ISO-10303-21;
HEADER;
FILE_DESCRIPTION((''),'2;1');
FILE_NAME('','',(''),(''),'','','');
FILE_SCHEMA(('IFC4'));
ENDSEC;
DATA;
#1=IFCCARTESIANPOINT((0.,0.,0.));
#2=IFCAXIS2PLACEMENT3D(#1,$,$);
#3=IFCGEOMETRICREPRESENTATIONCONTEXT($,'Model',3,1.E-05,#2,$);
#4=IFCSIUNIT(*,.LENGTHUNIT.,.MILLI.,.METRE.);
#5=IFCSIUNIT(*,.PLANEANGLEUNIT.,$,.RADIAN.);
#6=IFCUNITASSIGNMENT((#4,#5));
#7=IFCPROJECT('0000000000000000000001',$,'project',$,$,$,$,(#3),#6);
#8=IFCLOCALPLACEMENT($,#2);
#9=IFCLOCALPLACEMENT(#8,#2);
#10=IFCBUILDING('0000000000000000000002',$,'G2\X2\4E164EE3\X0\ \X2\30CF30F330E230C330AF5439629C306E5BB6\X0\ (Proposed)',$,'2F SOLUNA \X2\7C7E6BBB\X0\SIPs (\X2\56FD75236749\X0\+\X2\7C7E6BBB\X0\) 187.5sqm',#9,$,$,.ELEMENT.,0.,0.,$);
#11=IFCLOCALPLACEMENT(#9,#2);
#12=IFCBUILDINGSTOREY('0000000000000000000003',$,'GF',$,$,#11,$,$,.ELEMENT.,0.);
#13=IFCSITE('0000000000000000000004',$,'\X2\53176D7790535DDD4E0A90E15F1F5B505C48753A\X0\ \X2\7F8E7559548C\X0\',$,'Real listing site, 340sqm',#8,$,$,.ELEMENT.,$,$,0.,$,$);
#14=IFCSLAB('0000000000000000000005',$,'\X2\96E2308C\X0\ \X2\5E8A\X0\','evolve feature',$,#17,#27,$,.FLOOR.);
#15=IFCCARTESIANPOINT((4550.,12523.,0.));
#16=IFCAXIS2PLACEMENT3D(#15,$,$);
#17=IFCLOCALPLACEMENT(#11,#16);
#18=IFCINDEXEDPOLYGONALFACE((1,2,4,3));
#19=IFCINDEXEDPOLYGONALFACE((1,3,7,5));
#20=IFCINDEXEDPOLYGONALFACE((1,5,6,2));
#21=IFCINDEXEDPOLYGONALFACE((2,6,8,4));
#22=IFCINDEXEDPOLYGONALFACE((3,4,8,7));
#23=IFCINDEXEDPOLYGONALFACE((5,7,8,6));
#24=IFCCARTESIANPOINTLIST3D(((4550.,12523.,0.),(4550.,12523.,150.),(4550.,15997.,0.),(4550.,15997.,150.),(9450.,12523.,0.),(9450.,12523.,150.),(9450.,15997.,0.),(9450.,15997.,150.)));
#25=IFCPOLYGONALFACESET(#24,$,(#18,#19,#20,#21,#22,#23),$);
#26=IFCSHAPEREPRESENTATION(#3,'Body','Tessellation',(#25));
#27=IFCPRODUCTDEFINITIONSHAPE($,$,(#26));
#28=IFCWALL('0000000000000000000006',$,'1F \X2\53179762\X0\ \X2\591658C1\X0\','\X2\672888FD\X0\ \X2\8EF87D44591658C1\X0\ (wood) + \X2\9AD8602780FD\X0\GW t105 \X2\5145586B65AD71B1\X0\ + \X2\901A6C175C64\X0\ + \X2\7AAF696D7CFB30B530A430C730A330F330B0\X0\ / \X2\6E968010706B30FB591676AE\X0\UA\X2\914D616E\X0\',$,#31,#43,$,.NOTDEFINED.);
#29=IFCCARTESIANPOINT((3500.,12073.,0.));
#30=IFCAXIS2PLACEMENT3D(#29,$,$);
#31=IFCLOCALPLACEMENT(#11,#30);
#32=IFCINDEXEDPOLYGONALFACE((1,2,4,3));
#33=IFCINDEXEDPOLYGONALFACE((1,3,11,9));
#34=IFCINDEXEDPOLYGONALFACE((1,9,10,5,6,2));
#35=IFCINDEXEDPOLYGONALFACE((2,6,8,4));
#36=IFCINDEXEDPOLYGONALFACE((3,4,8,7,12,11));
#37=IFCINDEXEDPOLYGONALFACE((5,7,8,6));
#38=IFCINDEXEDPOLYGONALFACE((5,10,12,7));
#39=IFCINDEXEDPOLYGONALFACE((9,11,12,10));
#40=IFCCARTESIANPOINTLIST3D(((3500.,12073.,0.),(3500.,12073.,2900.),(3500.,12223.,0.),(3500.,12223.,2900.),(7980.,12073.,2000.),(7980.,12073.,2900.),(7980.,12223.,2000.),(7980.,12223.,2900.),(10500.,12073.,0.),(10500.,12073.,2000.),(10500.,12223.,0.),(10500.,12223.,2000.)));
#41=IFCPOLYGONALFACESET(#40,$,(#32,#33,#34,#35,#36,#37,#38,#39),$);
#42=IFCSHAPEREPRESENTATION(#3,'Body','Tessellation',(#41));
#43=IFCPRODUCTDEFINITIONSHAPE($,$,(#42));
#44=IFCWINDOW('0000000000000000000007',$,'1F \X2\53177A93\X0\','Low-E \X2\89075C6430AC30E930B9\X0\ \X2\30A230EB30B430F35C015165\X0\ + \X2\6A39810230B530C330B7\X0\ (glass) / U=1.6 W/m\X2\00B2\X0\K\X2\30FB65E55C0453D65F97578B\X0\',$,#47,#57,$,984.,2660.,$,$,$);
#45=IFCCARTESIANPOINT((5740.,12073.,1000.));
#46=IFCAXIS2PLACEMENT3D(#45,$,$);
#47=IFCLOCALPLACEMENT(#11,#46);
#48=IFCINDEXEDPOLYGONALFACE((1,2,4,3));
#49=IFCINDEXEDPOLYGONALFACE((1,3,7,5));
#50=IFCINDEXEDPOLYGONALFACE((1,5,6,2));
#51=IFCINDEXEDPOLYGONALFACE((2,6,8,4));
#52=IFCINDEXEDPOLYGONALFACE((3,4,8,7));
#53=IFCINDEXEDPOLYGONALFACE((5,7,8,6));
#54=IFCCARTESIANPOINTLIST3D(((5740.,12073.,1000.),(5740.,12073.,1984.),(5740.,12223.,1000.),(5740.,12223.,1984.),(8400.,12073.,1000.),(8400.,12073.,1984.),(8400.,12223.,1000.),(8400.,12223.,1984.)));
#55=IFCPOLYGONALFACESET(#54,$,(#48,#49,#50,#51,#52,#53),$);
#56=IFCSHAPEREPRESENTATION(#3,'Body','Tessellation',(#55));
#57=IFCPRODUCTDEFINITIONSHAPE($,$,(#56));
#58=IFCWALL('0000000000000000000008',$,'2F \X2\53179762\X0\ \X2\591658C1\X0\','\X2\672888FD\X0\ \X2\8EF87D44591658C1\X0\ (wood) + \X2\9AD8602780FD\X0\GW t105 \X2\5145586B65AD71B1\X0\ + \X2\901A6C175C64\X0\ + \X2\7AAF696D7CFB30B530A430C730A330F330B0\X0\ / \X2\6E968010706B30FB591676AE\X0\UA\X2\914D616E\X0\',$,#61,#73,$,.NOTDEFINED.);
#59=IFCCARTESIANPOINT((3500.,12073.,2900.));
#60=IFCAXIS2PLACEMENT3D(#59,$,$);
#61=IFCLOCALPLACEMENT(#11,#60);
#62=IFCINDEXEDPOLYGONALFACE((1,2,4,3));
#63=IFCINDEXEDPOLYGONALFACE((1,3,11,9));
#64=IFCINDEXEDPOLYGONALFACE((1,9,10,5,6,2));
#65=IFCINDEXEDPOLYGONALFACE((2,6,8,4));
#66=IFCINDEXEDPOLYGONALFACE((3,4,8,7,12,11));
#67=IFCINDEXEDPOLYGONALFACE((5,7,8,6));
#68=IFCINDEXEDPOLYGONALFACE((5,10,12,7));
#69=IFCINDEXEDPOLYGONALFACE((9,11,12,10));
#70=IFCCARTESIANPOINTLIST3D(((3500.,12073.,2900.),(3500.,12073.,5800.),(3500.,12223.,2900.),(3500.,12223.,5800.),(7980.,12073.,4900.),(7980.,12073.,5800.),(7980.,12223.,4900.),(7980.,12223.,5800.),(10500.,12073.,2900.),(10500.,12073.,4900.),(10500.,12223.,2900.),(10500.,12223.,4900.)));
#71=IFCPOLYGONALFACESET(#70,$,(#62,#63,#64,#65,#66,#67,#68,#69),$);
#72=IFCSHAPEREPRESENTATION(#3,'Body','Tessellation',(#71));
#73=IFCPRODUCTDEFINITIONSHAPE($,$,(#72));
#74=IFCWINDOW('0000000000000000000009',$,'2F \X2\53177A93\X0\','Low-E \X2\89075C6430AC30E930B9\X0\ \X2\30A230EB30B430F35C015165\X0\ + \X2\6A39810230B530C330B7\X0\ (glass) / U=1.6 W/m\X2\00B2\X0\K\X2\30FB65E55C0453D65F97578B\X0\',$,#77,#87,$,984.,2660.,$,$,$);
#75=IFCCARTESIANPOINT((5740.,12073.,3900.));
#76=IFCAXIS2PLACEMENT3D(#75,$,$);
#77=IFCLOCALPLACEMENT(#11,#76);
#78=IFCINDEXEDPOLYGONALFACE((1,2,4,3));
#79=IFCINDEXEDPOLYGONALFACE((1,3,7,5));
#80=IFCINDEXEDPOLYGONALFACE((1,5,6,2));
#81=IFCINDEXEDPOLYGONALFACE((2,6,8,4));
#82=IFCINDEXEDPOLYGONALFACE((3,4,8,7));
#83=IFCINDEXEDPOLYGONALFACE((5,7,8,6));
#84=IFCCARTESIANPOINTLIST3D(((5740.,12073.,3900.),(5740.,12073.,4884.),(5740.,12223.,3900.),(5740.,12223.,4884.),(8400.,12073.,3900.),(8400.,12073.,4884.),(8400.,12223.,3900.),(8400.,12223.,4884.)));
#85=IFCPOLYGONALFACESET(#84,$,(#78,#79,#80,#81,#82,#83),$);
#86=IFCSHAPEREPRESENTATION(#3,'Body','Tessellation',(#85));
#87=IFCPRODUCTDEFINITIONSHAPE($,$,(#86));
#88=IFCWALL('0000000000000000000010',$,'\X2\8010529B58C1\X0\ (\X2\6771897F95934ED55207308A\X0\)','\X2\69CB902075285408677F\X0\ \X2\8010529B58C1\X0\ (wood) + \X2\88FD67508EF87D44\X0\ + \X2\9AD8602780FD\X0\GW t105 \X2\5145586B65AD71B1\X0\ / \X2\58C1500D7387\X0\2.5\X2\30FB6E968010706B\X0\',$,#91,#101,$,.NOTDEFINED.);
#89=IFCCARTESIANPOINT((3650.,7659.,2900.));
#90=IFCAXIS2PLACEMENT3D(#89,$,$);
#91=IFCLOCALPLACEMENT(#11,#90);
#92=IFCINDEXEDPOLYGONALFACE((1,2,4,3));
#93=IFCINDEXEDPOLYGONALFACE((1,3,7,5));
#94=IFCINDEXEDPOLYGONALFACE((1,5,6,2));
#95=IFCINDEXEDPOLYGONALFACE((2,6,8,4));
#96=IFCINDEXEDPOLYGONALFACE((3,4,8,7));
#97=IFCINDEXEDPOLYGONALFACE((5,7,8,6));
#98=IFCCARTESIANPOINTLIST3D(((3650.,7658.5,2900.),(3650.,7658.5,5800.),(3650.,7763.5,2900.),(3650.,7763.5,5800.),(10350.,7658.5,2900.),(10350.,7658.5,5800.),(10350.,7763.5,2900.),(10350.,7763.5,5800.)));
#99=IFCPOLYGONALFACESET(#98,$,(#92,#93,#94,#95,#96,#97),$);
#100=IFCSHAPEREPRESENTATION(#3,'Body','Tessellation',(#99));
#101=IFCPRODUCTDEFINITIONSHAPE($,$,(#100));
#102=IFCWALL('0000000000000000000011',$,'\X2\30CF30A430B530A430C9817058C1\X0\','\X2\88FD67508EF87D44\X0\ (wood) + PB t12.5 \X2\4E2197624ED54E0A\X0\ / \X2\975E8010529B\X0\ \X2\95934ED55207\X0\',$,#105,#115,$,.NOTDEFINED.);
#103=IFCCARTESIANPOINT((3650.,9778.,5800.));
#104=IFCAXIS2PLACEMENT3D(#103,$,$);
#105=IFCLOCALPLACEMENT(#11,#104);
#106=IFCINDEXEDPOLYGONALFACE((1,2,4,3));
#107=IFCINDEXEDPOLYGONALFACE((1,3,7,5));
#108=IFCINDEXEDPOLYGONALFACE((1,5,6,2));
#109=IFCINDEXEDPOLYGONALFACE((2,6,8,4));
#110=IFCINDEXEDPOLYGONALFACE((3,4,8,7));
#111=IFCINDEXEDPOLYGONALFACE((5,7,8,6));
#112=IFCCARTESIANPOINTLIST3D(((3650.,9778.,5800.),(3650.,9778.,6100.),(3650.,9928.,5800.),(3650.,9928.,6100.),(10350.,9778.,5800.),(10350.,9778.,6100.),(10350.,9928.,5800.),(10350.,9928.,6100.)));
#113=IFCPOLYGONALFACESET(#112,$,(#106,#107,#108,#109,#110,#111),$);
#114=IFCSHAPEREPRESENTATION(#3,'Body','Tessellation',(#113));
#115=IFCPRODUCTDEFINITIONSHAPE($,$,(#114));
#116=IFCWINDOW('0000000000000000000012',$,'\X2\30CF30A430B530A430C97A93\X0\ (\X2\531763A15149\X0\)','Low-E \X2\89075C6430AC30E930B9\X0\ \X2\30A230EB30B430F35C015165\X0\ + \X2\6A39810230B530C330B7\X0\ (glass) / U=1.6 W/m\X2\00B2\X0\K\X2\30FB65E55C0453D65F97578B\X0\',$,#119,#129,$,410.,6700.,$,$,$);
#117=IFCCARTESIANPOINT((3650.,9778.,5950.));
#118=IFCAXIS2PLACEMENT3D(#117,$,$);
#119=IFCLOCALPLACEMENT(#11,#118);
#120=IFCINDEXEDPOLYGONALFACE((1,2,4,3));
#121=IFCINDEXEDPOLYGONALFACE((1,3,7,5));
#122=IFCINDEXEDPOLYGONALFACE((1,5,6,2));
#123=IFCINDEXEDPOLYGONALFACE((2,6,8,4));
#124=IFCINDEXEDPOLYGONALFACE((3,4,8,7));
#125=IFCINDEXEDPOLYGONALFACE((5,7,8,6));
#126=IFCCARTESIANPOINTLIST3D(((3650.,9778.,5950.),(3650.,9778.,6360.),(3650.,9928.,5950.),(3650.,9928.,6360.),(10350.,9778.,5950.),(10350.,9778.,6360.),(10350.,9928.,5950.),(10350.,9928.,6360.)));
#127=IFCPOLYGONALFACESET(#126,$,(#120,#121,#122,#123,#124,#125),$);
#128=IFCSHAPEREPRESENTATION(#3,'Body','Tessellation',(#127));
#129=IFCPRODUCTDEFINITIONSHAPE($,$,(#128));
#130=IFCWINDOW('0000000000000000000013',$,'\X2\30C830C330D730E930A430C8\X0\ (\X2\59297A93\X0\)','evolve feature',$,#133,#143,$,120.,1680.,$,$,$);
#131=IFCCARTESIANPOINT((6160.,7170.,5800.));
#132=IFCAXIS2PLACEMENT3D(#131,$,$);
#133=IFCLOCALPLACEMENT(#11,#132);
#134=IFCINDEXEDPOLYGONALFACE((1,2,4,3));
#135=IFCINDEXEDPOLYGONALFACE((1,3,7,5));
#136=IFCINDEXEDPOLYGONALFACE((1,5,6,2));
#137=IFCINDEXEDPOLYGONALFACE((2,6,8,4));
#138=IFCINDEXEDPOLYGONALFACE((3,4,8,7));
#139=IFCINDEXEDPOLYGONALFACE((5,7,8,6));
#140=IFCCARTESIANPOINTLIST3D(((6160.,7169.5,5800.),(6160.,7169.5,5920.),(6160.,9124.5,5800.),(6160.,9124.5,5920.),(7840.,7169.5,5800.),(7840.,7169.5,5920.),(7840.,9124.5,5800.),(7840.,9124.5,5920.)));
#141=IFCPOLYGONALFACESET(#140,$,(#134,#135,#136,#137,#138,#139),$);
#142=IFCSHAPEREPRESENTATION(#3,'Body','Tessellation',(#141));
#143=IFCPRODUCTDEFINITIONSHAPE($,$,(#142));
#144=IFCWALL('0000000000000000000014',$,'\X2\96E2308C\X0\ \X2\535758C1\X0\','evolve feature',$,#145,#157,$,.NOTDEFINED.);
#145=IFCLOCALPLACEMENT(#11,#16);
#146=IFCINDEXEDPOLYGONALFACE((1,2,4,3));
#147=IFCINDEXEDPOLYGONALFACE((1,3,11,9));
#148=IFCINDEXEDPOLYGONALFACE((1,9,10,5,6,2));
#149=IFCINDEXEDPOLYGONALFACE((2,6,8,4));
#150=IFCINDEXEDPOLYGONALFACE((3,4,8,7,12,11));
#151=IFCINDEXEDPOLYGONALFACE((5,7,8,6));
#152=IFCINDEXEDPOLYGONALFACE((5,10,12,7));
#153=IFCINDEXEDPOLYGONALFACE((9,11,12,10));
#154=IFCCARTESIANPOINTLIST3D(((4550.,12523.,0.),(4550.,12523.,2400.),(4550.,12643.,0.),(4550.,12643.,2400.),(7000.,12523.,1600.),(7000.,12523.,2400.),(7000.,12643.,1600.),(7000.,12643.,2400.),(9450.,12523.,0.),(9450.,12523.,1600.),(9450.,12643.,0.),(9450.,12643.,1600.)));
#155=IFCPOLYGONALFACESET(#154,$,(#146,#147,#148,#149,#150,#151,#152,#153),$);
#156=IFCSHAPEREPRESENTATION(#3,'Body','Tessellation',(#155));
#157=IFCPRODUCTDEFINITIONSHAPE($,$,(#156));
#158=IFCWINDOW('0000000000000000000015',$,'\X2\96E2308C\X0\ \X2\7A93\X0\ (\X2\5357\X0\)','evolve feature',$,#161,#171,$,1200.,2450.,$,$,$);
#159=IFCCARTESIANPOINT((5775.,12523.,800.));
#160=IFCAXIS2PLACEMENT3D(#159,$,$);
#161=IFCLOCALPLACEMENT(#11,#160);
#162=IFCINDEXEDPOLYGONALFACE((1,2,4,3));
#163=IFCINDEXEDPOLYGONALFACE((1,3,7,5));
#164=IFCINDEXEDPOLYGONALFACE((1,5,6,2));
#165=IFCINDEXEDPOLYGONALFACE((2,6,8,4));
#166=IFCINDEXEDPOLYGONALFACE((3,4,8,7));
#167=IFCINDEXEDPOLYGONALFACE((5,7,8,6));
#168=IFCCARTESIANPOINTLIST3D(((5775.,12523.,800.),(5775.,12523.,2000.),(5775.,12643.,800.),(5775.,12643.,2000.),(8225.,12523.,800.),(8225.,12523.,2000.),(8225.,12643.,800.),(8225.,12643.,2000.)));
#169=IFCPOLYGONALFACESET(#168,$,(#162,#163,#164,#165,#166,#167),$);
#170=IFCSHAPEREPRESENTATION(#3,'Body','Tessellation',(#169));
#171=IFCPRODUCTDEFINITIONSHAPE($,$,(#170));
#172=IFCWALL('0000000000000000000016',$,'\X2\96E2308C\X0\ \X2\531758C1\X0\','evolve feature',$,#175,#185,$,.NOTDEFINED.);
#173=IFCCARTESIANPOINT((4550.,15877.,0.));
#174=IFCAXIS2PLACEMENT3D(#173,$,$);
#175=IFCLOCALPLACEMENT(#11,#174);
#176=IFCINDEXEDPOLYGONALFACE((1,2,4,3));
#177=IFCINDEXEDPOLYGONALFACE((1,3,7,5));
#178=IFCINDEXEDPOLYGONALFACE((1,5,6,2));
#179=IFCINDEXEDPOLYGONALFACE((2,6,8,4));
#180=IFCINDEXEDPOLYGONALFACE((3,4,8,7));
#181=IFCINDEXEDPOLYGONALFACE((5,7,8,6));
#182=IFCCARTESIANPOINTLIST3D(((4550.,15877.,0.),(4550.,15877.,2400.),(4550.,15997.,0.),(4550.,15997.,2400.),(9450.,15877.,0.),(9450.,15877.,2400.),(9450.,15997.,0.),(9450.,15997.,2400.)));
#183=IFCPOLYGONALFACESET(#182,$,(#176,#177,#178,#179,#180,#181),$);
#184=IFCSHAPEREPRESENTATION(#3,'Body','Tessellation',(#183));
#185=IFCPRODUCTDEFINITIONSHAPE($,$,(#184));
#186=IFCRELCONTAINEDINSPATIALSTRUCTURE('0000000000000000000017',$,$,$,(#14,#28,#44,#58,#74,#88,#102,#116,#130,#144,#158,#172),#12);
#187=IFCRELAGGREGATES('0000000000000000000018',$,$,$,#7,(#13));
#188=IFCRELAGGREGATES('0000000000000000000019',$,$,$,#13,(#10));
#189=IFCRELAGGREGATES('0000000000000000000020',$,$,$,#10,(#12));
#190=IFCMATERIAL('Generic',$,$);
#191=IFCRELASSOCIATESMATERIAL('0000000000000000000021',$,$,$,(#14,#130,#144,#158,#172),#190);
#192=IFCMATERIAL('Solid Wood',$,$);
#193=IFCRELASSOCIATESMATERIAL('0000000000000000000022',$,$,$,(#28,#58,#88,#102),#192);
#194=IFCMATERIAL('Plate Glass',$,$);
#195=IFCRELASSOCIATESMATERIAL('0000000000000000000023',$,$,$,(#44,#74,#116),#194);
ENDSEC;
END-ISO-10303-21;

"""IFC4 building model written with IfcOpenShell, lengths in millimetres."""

from ifc_helpers import new_model, si_unit, frame, frame_2d, origin, place, context, project, spatial, rectangle, extrude, material, element, fill, save


model = new_model("IFC4")

# Units and contexts
model_context = context("Model", 3, precision=1e-05, world=origin())
ifc_project = project(units=[si_unit("LENGTHUNIT", "METRE", prefix="MILLI"), si_unit("PLANEANGLEUNIT", "RADIAN")], contexts=[model_context])

# Site, building, storey
site_placement = place(None, origin())
site = spatial("IfcSite", under=ifc_project, at=site_placement, Name="北海道川上郡弟子屈町 美留和", ObjectType="Real listing site, 340sqm", CompositionType="ELEMENT", RefElevation=0.0)
building_placement = place(site_placement, origin())
building = spatial("IfcBuilding", under=site, at=building_placement, Name="G2世代 ハンモック吹抜の家 (Proposed)", ObjectType="2F SOLUNA 籾殻SIPs (国産杉+籾殻) 187.5sqm", CompositionType="ELEMENT", ElevationOfRefHeight=0.0, ElevationOfTerrain=0.0)
storey_placement = place(building_placement, origin())
storey = spatial("IfcBuildingStorey", under=building, at=storey_placement, Name="GF", CompositionType="ELEMENT", Elevation=0.0)

# Slab
ifc_material_1 = material(Name="Generic")
slab_placement = place(storey_placement, frame((4550.0, 12523.0, 0.0)))
element("IfcSlab", 1, at=slab_placement, inside=storey, material=ifc_material_1, Name="離れ 床", Description="evolve feature", PredefinedType="FLOOR", context=model_context, shape_type="SweptSolid", body=[
    extrude(rectangle(XDim=4900.0, YDim=3474.0, at=frame_2d((2450.0, 1737.0))), frame((4550.0, 12523.0, 0.0)), (0.0, 0.0, 1.0), 150.0),
])

# Wall, opening, window
ifc_material_2 = material(Name="Solid Wood")
wall_1_placement = place(storey_placement, frame((3500.0, 12073.0, 0.0)))
wall_1 = element("IfcWall", 2, at=wall_1_placement, inside=storey, material=ifc_material_2, Name="1F 北面 外壁", Description="木製 軸組外壁 (wood) + 高性能GW t105 充填断熱 + 通気層 + 窯業系サイディング / 準耐火・外皮UA配慮", PredefinedType="NOTDEFINED", context=model_context, shape_type="SweptSolid", body=[
    extrude(rectangle(XDim=7000.0, YDim=150.0, at=frame_2d((3500.0, 75.0))), frame((3500.0, 12073.0, 0.0)), (0.0, 0.0, 1.0), 2900.0),
])
opening_1_placement = place(storey_placement, frame((5740.0, 12073.0, 1000.0)))
opening_1 = element("IfcOpeningElement", 3, at=opening_1_placement, cuts=wall_1, PredefinedType="NOTDEFINED", context=model_context, shape_type="SweptSolid", body=[
    extrude(rectangle(XDim=2660.0, YDim=150.0, at=frame_2d((1330.0, 75.0))), frame((5740.0, 12073.0, 1000.0)), (0.0, 0.0, 1.0), 984.0),
])
ifc_material_3 = material(Name="Plate Glass")
window_1_placement = place(storey_placement, frame((5740.0, 12073.0, 1000.0)))
window_1 = element("IfcWindow", 4, at=window_1_placement, inside=storey, material=ifc_material_3, Name="1F 北窓", Description="Low-E 複層ガラス アルゴン封入 + 樹脂サッシ (glass) / U=1.6 W/m²K・日射取得型", OverallHeight=984.0, OverallWidth=2660.0, context=model_context, shape_type="SweptSolid", body=[
    extrude(rectangle(XDim=2660.0, YDim=150.0, at=frame_2d((1330.0, 75.0))), frame((5740.0, 12073.0, 1000.0)), (0.0, 0.0, 1.0), 984.0),
])
fill(opening_1, window_1)

# Wall, opening, window
wall_2_placement = place(storey_placement, frame((3500.0, 12073.0, 2900.0)))
wall_2 = element("IfcWall", 5, at=wall_2_placement, inside=storey, material=ifc_material_2, Name="2F 北面 外壁", Description="木製 軸組外壁 (wood) + 高性能GW t105 充填断熱 + 通気層 + 窯業系サイディング / 準耐火・外皮UA配慮", PredefinedType="NOTDEFINED", context=model_context, shape_type="SweptSolid", body=[
    extrude(rectangle(XDim=7000.0, YDim=150.0, at=frame_2d((3500.0, 75.0))), frame((3500.0, 12073.0, 2900.0)), (0.0, 0.0, 1.0), 2900.0),
])
opening_2_placement = place(storey_placement, frame((5740.0, 12073.0, 3900.0)))
opening_2 = element("IfcOpeningElement", 6, at=opening_2_placement, cuts=wall_2, PredefinedType="NOTDEFINED", context=model_context, shape_type="SweptSolid", body=[
    extrude(rectangle(XDim=2660.0, YDim=150.0, at=frame_2d((1330.0, 75.0))), frame((5740.0, 12073.0, 3900.0)), (0.0, 0.0, 1.0), 984.0),
])
window_2_placement = place(storey_placement, frame((5740.0, 12073.0, 3900.0)))
window_2 = element("IfcWindow", 7, at=window_2_placement, inside=storey, material=ifc_material_3, Name="2F 北窓", Description="Low-E 複層ガラス アルゴン封入 + 樹脂サッシ (glass) / U=1.6 W/m²K・日射取得型", OverallHeight=984.0, OverallWidth=2660.0, context=model_context, shape_type="SweptSolid", body=[
    extrude(rectangle(XDim=2660.0, YDim=150.0, at=frame_2d((1330.0, 75.0))), frame((5740.0, 12073.0, 3900.0)), (0.0, 0.0, 1.0), 984.0),
])
fill(opening_2, window_2)

# Wall
wall_3_placement = place(storey_placement, frame((3650.0, 7659.0, 2900.0)))
element("IfcWall", 8, at=wall_3_placement, inside=storey, material=ifc_material_2, Name="耐力壁 (東西間仕切り)", Description="構造用合板 耐力壁 (wood) + 製材軸組 + 高性能GW t105 充填断熱 / 壁倍率2.5・準耐火", PredefinedType="NOTDEFINED", context=model_context, shape_type="SweptSolid", body=[
    extrude(rectangle(XDim=6700.0, YDim=105.0, at=frame_2d((3350.0, 52.0))), frame((3650.0, 7659.0, 2900.0)), (0.0, 0.0, 1.0), 2900.0),
])

# Wall, opening, window
wall_4_placement = place(storey_placement, frame((3650.0, 9778.0, 5800.0)))
wall_4 = element("IfcWall", 9, at=wall_4_placement, inside=storey, material=ifc_material_2, Name="ハイサイド腰壁", Description="製材軸組 (wood) + PB t12.5 両面仕上 / 非耐力 間仕切", PredefinedType="NOTDEFINED", context=model_context, shape_type="SweptSolid", body=[
    extrude(rectangle(XDim=6700.0, YDim=150.0, at=frame_2d((3350.0, 75.0))), frame((3650.0, 9778.0, 5800.0)), (0.0, 0.0, 1.0), 700.0),
])
opening_3_placement = place(storey_placement, frame((3650.0, 9778.0, 5950.0)))
opening_3 = element("IfcOpeningElement", 10, at=opening_3_placement, cuts=wall_4, PredefinedType="NOTDEFINED", context=model_context, shape_type="SweptSolid", body=[
    extrude(rectangle(XDim=6700.0, YDim=150.0, at=frame_2d((3350.0, 75.0))), frame((3650.0, 9778.0, 5950.0)), (0.0, 0.0, 1.0), 410.0),
])
window_3_placement = place(storey_placement, frame((3650.0, 9778.0, 5950.0)))
window_3 = element("IfcWindow", 11, at=window_3_placement, inside=storey, material=ifc_material_3, Name="ハイサイド窓 (北採光)", Description="Low-E 複層ガラス アルゴン封入 + 樹脂サッシ (glass) / U=1.6 W/m²K・日射取得型", OverallHeight=410.0, OverallWidth=6700.0, context=model_context, shape_type="SweptSolid", body=[
    extrude(rectangle(XDim=6700.0, YDim=150.0, at=frame_2d((3350.0, 75.0))), frame((3650.0, 9778.0, 5950.0)), (0.0, 0.0, 1.0), 410.0),
])
fill(opening_3, window_3)

# Window
window_4_placement = place(storey_placement, frame((6160.0, 7170.0, 5800.0)))
element("IfcWindow", 12, at=window_4_placement, inside=storey, material=ifc_material_1, Name="トップライト (天窓)", Description="evolve feature", OverallHeight=120.0, OverallWidth=1680.0, context=model_context, shape_type="SweptSolid", body=[
    extrude(rectangle(XDim=1680.0, YDim=1955.0, at=frame_2d((840.0, 977.0))), frame((6160.0, 7170.0, 5800.0)), (0.0, 0.0, 1.0), 120.0),
])

# Wall, opening, window
wall_5_placement = place(storey_placement, frame((4550.0, 12523.0, 0.0)))
wall_5 = element("IfcWall", 13, at=wall_5_placement, inside=storey, material=ifc_material_1, Name="離れ 南壁", Description="evolve feature", PredefinedType="NOTDEFINED", context=model_context, shape_type="SweptSolid", body=[
    extrude(rectangle(XDim=4900.0, YDim=120.0, at=frame_2d((2450.0, 60.0))), frame((4550.0, 12523.0, 0.0)), (0.0, 0.0, 1.0), 2400.0),
])
opening_4_placement = place(storey_placement, frame((5775.0, 12523.0, 800.0)))
opening_4 = element("IfcOpeningElement", 14, at=opening_4_placement, cuts=wall_5, PredefinedType="NOTDEFINED", context=model_context, shape_type="SweptSolid", body=[
    extrude(rectangle(XDim=2450.0, YDim=120.0, at=frame_2d((1225.0, 60.0))), frame((5775.0, 12523.0, 800.0)), (0.0, 0.0, 1.0), 1200.0),
])
window_5_placement = place(storey_placement, frame((5775.0, 12523.0, 800.0)))
window_5 = element("IfcWindow", 15, at=window_5_placement, inside=storey, material=ifc_material_1, Name="離れ 窓 (南)", Description="evolve feature", OverallHeight=1200.0, OverallWidth=2450.0, context=model_context, shape_type="SweptSolid", body=[
    extrude(rectangle(XDim=2450.0, YDim=120.0, at=frame_2d((1225.0, 60.0))), frame((5775.0, 12523.0, 800.0)), (0.0, 0.0, 1.0), 1200.0),
])
fill(opening_4, window_5)

# Wall
wall_6_placement = place(storey_placement, frame((4550.0, 15877.0, 0.0)))
element("IfcWall", 16, at=wall_6_placement, inside=storey, material=ifc_material_1, Name="離れ 北壁", Description="evolve feature", PredefinedType="NOTDEFINED", context=model_context, shape_type="SweptSolid", body=[
    extrude(rectangle(XDim=4900.0, YDim=120.0, at=frame_2d((2450.0, 60.0))), frame((4550.0, 15877.0, 0.0)), (0.0, 0.0, 1.0), 2400.0),
])

save(model, "model.ifc")
